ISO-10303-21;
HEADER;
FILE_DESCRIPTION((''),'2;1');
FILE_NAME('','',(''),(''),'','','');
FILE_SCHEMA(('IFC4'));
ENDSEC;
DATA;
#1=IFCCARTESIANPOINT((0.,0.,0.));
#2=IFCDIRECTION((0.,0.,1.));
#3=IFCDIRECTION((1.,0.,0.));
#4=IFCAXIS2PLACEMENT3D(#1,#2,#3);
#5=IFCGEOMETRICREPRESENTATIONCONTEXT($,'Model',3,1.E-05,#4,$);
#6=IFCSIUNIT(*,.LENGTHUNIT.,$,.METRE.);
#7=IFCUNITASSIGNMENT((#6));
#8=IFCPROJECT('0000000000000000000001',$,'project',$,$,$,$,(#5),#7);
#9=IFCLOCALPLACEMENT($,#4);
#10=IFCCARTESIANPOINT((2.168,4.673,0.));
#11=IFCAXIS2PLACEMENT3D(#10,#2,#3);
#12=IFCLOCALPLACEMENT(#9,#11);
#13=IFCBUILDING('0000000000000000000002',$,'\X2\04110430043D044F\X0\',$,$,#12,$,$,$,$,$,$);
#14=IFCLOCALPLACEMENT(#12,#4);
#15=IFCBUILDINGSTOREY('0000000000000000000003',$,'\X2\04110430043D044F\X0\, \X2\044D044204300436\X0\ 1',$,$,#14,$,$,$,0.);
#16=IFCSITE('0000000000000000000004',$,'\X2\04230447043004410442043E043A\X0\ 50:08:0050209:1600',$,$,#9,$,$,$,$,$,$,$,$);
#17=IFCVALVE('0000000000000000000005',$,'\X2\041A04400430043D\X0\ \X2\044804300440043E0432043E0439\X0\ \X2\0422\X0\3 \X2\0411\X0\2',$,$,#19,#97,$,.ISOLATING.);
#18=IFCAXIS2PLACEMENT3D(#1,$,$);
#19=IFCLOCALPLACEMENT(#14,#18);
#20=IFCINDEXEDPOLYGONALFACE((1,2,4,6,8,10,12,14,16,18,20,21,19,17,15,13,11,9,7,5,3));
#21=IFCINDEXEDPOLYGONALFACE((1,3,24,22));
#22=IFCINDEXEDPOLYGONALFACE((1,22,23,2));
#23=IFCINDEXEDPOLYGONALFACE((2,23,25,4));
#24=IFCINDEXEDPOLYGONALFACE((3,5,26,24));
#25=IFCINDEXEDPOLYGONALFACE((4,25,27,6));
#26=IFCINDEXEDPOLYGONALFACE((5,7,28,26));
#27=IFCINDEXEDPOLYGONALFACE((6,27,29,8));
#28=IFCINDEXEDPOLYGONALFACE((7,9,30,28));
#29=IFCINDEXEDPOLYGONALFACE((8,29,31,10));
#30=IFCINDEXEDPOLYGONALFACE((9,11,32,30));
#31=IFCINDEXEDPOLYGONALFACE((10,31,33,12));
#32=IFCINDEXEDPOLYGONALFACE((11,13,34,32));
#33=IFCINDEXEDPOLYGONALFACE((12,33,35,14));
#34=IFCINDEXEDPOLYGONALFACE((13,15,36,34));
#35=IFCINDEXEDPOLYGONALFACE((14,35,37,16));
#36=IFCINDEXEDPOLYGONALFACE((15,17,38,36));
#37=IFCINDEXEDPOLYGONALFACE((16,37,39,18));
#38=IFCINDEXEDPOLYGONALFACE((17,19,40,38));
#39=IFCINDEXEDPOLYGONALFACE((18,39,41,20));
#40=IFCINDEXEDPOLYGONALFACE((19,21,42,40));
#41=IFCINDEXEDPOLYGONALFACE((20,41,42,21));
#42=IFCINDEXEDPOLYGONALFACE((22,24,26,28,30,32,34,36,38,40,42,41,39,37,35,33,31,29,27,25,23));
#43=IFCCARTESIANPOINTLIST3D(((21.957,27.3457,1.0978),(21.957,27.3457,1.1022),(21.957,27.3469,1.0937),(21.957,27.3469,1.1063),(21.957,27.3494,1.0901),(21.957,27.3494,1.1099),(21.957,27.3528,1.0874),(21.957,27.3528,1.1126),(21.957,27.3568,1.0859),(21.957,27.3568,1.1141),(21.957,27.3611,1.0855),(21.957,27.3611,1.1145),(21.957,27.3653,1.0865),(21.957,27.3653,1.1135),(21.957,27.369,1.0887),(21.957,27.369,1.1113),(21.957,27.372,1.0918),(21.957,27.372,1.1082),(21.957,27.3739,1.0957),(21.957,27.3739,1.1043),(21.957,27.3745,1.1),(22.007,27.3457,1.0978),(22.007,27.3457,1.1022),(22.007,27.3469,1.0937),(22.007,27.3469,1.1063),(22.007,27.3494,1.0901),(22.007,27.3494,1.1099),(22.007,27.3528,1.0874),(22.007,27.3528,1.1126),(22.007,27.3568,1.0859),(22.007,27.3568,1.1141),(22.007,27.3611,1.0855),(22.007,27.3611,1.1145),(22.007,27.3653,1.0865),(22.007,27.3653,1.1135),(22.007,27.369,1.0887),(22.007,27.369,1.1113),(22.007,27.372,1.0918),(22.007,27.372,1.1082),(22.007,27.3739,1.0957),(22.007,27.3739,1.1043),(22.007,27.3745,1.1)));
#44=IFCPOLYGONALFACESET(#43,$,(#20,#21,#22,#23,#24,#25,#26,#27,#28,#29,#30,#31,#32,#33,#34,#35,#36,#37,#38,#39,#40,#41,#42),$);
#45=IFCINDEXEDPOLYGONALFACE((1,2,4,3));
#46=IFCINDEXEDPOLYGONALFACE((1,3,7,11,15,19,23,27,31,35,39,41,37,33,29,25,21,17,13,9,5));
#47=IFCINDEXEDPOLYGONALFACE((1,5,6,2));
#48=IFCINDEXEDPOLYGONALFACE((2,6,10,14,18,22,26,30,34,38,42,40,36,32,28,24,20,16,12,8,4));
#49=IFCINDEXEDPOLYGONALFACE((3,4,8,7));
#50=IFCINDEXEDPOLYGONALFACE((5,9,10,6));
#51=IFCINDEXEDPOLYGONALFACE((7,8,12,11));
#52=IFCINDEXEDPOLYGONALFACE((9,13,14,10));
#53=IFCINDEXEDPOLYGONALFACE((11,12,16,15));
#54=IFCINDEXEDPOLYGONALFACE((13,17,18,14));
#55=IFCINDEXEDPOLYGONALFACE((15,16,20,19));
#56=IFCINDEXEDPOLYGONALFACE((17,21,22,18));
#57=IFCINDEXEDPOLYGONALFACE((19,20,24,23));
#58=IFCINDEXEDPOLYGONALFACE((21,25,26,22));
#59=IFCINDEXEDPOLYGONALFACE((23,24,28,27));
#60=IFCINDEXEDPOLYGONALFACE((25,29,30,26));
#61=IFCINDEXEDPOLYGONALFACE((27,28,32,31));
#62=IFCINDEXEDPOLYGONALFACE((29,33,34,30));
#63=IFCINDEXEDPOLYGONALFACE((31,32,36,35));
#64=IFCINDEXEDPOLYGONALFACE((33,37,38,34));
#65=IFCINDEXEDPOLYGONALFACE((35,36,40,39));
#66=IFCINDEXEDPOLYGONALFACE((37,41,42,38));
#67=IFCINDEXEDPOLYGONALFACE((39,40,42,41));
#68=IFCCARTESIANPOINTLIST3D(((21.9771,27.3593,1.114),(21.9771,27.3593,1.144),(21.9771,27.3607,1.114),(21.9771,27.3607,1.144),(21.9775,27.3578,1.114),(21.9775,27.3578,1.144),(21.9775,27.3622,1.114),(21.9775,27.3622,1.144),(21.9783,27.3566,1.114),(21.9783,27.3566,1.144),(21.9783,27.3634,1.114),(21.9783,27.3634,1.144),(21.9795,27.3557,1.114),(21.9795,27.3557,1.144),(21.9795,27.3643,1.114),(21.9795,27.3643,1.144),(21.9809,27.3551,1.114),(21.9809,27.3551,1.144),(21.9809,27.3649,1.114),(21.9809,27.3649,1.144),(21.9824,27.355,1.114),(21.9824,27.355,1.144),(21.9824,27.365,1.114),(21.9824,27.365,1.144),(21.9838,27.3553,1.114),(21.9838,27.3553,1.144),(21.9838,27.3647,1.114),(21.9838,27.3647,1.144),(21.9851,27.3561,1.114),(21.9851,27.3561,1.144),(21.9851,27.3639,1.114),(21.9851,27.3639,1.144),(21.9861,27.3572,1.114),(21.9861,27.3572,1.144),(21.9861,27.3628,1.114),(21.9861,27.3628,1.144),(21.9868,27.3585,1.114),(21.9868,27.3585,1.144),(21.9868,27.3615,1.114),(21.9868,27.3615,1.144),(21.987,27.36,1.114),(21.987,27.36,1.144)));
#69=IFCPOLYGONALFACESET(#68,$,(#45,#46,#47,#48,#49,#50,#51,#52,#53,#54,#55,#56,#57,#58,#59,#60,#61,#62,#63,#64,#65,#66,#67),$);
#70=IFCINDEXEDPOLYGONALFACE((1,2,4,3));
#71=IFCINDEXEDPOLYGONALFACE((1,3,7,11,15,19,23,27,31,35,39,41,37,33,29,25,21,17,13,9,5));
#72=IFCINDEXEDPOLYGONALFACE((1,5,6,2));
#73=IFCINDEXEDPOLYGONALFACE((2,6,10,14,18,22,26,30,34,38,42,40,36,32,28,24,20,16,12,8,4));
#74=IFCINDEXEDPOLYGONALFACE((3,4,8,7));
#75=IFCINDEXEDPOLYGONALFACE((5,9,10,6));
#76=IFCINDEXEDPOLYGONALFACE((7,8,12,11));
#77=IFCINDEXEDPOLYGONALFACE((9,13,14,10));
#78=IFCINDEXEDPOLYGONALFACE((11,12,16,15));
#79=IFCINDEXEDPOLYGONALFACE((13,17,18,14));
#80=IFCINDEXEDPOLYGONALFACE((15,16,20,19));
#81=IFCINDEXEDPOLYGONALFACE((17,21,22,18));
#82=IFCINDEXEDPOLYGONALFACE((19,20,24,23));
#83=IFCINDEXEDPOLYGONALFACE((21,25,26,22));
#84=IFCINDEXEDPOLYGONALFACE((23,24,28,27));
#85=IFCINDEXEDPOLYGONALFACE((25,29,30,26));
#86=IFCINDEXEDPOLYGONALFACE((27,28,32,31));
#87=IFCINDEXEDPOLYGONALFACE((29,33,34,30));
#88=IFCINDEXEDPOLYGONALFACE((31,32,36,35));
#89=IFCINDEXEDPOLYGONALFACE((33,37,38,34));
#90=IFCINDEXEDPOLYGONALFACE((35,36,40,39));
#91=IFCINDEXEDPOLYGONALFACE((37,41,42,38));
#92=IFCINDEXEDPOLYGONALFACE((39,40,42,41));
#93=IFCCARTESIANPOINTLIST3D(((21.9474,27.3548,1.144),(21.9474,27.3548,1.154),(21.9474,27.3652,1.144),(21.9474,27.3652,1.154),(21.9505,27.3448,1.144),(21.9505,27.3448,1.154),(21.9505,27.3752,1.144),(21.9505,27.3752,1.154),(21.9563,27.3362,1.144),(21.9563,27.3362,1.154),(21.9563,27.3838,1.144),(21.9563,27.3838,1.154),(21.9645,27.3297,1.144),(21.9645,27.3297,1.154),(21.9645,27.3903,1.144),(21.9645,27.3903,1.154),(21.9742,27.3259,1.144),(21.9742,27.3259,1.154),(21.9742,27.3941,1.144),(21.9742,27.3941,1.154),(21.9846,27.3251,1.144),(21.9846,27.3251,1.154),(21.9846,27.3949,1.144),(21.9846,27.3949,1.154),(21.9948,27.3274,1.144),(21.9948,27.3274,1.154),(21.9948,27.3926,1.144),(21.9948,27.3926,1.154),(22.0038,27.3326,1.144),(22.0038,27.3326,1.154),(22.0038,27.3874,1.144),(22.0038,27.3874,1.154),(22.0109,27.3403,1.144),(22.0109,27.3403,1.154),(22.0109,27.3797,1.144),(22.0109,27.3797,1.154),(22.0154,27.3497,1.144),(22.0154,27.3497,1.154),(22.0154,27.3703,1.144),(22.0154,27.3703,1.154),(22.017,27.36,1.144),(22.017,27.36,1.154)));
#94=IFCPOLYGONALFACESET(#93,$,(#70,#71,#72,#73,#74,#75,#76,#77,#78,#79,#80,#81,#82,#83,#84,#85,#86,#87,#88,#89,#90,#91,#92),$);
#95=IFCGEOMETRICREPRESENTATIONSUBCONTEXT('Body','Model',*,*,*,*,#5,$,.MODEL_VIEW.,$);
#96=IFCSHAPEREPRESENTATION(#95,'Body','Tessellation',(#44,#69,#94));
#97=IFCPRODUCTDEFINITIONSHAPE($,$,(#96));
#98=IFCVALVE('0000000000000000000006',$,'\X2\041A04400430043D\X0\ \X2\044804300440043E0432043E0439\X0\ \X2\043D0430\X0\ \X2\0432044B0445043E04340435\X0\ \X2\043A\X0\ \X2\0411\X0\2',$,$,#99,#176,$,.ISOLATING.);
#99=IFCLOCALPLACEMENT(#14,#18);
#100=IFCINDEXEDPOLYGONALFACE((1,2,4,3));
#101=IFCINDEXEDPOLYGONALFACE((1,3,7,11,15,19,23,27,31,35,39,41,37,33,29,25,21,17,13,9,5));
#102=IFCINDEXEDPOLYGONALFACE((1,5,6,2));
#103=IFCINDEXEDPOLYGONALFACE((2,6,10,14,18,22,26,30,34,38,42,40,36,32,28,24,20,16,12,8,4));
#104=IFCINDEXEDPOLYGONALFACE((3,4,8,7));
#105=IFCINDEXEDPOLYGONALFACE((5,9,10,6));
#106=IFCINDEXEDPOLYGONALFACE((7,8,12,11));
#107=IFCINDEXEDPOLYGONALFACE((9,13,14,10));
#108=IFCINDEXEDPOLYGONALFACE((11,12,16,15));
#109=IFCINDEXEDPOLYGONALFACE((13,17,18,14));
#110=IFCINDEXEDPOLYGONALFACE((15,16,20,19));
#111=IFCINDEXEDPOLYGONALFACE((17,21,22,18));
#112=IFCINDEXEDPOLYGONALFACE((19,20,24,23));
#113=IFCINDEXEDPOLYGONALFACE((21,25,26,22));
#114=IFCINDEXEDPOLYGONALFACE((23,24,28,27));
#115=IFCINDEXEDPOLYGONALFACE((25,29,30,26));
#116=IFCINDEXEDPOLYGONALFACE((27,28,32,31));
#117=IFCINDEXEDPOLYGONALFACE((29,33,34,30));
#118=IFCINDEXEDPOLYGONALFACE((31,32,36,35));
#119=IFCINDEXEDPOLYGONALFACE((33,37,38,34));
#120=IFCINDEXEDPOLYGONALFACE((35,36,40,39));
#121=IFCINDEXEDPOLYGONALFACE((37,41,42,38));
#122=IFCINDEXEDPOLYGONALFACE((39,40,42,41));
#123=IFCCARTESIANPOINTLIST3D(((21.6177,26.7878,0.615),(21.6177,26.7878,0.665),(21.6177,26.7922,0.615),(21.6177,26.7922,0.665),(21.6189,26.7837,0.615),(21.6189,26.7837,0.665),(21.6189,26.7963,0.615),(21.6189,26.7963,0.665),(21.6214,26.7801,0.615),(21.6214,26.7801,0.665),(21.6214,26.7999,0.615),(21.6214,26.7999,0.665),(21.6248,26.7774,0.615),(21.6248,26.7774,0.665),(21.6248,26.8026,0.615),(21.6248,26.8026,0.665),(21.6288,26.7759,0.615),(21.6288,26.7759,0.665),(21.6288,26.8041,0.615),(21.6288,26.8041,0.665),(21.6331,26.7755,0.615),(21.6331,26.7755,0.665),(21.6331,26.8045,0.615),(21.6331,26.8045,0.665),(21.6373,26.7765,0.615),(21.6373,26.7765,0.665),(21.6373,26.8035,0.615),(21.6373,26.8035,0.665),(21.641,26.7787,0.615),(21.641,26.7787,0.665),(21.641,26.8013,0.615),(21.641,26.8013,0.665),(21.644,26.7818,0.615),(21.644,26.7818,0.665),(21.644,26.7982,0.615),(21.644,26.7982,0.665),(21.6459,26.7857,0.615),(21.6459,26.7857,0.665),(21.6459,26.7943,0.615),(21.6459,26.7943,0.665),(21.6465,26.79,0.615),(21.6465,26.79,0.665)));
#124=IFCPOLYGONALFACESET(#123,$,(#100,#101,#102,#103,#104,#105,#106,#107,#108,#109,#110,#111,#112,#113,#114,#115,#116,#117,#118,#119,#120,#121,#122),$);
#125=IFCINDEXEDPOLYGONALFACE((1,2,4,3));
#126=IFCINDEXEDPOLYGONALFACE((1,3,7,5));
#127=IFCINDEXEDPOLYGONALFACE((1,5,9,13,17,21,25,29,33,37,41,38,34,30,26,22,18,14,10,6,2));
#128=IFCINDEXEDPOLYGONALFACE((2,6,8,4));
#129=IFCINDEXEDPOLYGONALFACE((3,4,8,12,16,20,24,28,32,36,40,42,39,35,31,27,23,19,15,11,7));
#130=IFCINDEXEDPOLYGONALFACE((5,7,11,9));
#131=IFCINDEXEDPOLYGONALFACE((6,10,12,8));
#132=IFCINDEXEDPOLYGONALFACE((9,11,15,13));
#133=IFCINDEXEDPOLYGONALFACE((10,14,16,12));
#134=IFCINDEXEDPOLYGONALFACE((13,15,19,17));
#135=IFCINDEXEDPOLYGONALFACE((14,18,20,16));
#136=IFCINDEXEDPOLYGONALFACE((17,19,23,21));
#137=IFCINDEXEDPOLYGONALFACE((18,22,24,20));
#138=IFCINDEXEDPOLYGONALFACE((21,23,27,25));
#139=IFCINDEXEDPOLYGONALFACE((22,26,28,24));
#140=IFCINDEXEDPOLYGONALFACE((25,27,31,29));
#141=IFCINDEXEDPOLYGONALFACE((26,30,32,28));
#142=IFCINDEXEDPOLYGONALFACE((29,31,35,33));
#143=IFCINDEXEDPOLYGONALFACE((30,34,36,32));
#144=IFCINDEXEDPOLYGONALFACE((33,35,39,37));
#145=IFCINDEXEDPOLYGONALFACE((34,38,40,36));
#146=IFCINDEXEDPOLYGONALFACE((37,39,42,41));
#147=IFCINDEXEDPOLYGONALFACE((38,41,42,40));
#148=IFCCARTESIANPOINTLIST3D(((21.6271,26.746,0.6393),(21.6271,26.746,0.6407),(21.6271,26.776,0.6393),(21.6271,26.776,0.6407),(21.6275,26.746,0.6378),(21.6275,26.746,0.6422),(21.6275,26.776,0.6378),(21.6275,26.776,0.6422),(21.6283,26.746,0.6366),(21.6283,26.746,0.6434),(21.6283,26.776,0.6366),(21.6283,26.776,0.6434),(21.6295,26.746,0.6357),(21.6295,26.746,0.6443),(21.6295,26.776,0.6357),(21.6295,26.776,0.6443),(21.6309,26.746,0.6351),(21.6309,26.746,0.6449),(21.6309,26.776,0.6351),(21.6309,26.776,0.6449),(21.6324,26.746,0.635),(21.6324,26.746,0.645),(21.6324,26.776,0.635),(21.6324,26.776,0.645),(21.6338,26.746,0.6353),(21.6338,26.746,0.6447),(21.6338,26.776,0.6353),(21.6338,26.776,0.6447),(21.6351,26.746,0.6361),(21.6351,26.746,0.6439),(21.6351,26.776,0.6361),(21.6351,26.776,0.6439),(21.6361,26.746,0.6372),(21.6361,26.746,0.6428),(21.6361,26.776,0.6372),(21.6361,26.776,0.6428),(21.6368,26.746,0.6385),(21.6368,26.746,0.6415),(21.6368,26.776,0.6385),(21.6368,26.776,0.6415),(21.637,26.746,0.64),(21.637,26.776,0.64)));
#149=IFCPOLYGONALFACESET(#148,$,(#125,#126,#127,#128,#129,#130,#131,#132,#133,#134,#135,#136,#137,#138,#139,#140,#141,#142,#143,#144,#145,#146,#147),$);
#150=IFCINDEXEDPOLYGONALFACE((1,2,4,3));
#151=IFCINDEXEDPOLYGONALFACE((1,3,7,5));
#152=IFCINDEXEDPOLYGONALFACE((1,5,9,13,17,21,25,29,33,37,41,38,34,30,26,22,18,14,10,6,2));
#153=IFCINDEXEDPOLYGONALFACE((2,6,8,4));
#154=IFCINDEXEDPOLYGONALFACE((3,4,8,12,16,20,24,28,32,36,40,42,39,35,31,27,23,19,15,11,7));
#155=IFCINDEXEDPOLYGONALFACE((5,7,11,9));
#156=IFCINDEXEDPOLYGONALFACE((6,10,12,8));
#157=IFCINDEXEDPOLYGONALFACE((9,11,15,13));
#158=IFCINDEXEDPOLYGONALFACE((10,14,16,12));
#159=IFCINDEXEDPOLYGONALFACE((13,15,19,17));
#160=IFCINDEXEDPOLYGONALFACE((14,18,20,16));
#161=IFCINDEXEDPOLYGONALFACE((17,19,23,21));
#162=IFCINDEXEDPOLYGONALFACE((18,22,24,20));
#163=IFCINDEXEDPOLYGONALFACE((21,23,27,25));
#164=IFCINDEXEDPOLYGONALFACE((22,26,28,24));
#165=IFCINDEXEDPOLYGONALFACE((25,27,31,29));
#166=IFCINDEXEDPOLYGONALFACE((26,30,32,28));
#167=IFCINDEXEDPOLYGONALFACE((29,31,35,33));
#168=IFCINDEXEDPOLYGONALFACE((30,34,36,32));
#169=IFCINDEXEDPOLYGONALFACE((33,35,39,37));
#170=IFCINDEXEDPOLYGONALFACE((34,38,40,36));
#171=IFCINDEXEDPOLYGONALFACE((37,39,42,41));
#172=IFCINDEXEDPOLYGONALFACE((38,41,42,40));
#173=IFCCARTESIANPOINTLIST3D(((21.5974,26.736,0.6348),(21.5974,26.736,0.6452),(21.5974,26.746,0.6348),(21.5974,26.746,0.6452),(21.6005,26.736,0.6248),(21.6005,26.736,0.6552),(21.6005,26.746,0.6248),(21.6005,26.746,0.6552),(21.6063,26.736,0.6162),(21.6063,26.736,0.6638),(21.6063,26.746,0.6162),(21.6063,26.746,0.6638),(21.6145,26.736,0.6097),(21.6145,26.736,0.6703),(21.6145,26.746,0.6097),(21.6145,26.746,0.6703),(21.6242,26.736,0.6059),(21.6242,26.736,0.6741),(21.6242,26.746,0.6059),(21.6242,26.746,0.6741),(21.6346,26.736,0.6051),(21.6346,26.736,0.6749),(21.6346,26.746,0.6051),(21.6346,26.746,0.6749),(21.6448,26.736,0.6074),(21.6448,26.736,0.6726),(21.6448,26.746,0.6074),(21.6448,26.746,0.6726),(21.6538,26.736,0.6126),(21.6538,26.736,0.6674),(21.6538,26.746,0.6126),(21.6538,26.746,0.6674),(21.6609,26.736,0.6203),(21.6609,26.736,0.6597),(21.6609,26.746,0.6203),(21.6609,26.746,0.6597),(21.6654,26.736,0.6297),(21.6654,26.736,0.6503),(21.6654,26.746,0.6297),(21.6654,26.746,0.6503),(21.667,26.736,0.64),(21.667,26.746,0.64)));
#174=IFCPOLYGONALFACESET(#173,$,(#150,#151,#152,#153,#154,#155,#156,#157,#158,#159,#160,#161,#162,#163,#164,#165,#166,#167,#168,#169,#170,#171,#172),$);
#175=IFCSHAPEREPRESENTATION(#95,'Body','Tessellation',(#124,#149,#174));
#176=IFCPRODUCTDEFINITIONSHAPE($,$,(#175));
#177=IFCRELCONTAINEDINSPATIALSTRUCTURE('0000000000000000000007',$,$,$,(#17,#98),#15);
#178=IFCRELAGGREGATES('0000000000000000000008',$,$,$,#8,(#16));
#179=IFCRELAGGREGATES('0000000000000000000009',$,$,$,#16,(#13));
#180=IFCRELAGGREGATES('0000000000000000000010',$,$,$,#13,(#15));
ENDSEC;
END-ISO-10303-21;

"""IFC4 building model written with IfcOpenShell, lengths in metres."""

from ifc_helpers import new_model, si_unit, frame, origin_with_axes, origin_2d, place, context, subcontext, project, spatial, circle, extrude, element, save


model = new_model("IFC4")

# Units and contexts
model_context = context("Model", 3, precision=1e-05, world=origin_with_axes())
body_context = subcontext(model_context, "Body", "Model", "MODEL_VIEW")
ifc_project = project(units=[si_unit("LENGTHUNIT", "METRE")], contexts=[model_context])

# Site, building, storey
site_placement = place(None, origin_with_axes())
site = spatial("IfcSite", under=ifc_project, at=site_placement, Name="Участок 50:08:0050209:1600")
building_placement = place(site_placement, frame((2.168, 4.673, 0.0), z_axis=(0.0, 0.0, 1.0), x_axis=(1.0, 0.0, 0.0)))
building = spatial("IfcBuilding", under=site, at=building_placement, Name="Баня")
storey_placement = place(building_placement, origin_with_axes())
storey = spatial("IfcBuildingStorey", under=building, at=storey_placement, Name="Баня, этаж 1", Elevation=0.0)

# Valves
valve_1_placement = place(storey_placement, origin_with_axes())
element("IfcValve", 1, at=valve_1_placement, inside=storey, Name="Кран шаровой Т3 Б2", PredefinedType="ISOLATING", context=body_context, shape_type="SweptSolid", body=[
    extrude(circle(Radius=0.0145, at=origin_2d()), frame((21.957, 27.36, 1.1), z_axis=(1.0, 0.0, 0.0), x_axis=(0.0, 1.0, 0.0)), (0.0, 0.0, 1.0), 0.05),
    extrude(circle(Radius=0.005, at=origin_2d()), frame((21.982, 27.36, 1.114), z_axis=(0.0, 0.0, 1.0), x_axis=(1.0, 0.0, 0.0)), (0.0, 0.0, 1.0), 0.03),
    extrude(circle(Radius=0.035, at=origin_2d()), frame((21.982, 27.36, 1.144), z_axis=(0.0, 0.0, 1.0), x_axis=(1.0, 0.0, 0.0)), (0.0, 0.0, 1.0), 0.01),
])
valve_2_placement = place(storey_placement, origin_with_axes())
element("IfcValve", 2, at=valve_2_placement, inside=storey, Name="Кран шаровой на выходе к Б2", PredefinedType="ISOLATING", context=body_context, shape_type="SweptSolid", body=[
    extrude(circle(Radius=0.0145, at=origin_2d()), frame((21.632, 26.79, 0.615), z_axis=(0.0, 0.0, 1.0), x_axis=(1.0, 0.0, 0.0)), (0.0, 0.0, 1.0), 0.05),
    extrude(circle(Radius=0.005, at=origin_2d()), frame((21.632, 26.776, 0.64), z_axis=(0.0, -1.0, 0.0), x_axis=(1.0, 0.0, 0.0)), (0.0, 0.0, 1.0), 0.03),
    extrude(circle(Radius=0.035, at=origin_2d()), frame((21.632, 26.746, 0.64), z_axis=(0.0, -1.0, 0.0), x_axis=(1.0, 0.0, 0.0)), (0.0, 0.0, 1.0), 0.01),
])

save(model, "model.ifc")
